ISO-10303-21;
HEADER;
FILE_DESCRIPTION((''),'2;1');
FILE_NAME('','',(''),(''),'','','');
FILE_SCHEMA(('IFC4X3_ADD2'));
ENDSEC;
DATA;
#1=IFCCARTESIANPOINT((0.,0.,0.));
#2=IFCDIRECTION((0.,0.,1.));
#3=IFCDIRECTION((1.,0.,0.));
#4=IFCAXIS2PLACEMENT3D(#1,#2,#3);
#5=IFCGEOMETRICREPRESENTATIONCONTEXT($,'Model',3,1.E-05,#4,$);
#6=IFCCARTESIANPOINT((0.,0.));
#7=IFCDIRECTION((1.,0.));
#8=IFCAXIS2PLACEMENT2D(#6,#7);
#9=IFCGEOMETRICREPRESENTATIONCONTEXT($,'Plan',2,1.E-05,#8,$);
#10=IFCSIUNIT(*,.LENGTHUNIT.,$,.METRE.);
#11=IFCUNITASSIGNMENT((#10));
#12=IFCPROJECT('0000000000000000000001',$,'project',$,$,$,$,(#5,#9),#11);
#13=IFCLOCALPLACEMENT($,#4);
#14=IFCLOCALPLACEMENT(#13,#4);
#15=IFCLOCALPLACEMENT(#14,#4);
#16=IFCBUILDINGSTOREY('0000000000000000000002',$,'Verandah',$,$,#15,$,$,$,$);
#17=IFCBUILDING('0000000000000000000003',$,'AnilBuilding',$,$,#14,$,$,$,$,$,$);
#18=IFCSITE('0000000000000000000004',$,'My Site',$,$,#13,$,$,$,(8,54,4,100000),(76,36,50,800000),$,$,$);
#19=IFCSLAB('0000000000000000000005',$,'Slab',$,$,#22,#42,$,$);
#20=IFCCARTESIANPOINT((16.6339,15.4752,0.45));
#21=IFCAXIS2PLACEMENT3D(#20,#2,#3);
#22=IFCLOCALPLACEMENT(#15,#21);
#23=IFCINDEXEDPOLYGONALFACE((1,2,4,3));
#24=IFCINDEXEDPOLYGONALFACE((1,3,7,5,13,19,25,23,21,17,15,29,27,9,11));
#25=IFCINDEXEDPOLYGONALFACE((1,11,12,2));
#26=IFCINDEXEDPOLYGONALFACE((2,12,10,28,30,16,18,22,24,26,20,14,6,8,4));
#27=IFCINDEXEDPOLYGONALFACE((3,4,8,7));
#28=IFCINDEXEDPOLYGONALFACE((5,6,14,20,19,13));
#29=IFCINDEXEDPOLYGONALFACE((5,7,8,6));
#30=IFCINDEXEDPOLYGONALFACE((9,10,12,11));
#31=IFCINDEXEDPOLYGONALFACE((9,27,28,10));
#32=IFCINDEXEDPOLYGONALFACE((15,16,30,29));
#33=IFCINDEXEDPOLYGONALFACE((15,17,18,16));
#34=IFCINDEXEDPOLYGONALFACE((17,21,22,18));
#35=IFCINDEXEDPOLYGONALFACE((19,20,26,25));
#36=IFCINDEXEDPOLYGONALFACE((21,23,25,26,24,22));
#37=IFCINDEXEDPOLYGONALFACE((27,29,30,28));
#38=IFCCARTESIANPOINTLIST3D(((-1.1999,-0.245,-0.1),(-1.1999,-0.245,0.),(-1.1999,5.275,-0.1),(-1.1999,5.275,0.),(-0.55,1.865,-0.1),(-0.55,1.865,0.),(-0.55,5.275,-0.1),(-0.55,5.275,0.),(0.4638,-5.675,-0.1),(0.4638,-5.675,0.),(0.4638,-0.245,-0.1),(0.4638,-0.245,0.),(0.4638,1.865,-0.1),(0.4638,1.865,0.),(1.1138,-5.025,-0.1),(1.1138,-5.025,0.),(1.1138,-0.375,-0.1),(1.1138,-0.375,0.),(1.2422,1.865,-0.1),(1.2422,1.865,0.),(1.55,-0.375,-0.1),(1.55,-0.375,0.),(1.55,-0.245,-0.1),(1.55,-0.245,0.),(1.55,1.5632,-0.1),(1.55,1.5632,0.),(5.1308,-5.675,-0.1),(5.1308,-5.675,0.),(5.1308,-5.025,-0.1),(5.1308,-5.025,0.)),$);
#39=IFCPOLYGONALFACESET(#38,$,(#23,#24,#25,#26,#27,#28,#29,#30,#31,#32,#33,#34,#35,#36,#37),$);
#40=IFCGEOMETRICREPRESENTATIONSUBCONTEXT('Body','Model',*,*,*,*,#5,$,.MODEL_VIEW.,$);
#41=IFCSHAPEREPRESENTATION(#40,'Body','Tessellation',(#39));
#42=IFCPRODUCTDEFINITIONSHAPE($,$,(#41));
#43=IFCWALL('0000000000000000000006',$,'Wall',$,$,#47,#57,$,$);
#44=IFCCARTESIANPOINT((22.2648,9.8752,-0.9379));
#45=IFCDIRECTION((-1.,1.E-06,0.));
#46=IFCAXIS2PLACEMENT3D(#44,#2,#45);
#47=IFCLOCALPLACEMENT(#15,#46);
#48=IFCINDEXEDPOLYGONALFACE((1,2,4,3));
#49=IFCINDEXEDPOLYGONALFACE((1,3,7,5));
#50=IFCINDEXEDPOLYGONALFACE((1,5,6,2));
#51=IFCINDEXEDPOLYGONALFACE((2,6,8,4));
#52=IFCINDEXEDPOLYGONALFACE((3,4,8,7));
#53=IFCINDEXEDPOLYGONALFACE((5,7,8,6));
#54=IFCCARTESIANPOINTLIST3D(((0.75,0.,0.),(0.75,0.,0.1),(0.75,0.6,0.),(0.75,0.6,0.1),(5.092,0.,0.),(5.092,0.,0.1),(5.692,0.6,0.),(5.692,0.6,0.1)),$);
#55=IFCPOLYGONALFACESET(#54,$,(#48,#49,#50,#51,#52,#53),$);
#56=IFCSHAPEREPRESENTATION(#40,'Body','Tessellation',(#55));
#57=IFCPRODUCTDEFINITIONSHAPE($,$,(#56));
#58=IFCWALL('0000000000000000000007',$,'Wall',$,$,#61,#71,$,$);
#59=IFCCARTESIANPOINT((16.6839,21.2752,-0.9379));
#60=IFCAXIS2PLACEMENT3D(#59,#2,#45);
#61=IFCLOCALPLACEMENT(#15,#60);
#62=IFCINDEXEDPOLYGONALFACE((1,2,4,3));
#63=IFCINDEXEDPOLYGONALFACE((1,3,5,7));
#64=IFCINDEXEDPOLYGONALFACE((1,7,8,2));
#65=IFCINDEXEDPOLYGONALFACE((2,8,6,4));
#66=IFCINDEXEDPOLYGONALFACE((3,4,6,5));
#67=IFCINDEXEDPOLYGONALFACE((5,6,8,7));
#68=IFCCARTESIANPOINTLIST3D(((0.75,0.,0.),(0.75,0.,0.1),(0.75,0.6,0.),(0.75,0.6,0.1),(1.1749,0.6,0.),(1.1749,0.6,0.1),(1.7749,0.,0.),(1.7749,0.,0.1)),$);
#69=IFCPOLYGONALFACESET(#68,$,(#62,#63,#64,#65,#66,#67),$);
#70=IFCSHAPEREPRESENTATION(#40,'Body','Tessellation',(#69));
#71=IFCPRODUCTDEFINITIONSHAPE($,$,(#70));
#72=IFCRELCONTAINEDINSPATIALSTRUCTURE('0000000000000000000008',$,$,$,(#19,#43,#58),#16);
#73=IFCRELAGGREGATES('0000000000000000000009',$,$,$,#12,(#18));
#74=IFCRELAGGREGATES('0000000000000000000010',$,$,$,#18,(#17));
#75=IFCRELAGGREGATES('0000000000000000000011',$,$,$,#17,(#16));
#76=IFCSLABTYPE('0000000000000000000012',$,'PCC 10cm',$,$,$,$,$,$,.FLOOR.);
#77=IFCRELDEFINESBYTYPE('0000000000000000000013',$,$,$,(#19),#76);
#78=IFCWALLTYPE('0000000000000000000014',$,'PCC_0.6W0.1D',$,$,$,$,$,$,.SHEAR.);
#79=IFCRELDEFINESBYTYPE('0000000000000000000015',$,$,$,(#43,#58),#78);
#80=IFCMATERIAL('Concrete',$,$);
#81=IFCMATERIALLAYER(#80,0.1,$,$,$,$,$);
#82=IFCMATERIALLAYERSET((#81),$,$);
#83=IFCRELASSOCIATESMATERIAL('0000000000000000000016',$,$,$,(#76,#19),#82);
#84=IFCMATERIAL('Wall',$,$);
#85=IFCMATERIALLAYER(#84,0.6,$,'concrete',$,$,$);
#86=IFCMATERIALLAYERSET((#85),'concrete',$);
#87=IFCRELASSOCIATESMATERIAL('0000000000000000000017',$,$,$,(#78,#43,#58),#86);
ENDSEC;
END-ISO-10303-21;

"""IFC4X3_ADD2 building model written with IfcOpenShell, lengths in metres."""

from ifc_helpers import new_model, si_unit, frame, origin_with_axes, origin_2d_with_axis, place, context, subcontext, project, spatial, line, indexed_curve, outline, extrude, material, layer, layer_set, layer_usage, type_object, element, save


model = new_model("IFC4X3_ADD2")

# Units and contexts
model_context = context("Model", 3, precision=1e-05, world=origin_with_axes())
plan_context = context("Plan", 2, precision=1e-05, world=origin_2d_with_axis())
body_context = subcontext(model_context, "Body", "Model", "MODEL_VIEW")
ifc_project = project(units=[si_unit("LENGTHUNIT", "METRE")], contexts=[model_context, plan_context])

# Site, building, storey
site_placement = place(None, origin_with_axes())
site = spatial("IfcSite", under=ifc_project, at=site_placement, Name="My Site", RefLatitude=(8, 54, 4, 100000), RefLongitude=(76, 36, 50, 800000))
building_placement = place(site_placement, origin_with_axes())
building = spatial("IfcBuilding", under=site, at=building_placement, Name="AnilBuilding")
storey_placement = place(building_placement, origin_with_axes())
storey = spatial("IfcBuildingStorey", under=building, at=storey_placement, Name="Verandah")

# Slab
ifc_material_1 = material(Name="Concrete")
ifc_layer_1 = layer(ifc_material_1, 0.1)
ifc_layer_set_1 = layer_set([ifc_layer_1])
ifc_layer_usage_1 = layer_usage(ifc_layer_set_1, "AXIS3", "POSITIVE", -0.1)
slab_type = type_object("IfcSlabType", Name="PCC 10cm", PredefinedType="FLOOR", material=ifc_layer_set_1)
slab_placement = place(storey_placement, frame((16.6339, 15.4752, 0.45), z_axis=(0.0, 0.0, 1.0), x_axis=(1.0, 0.0, 0.0)))
element("IfcSlab", 1, at=slab_placement, inside=storey, type_object=slab_type, material=ifc_layer_usage_1, Name="Slab", context=body_context, shape_type="SweptSolid", body=[
    extrude(outline(indexed_curve([(1.55, -0.375), (1.1138, -0.375), (1.1138, -5.025), (5.1308, -5.025), (5.1308, -5.675), (0.4638, -5.675), (0.4638, -0.245), (-1.1999, -0.245), (-1.1999, 5.275), (-0.55, 5.275), (-0.55, 1.865), (0.4638, 1.865), (1.2422, 1.865), (1.55, 1.5632), (1.55, -0.245), (1.55, -0.375)])), frame((0.0, 0.0, -0.1), z_axis=(0.0, 0.0, 1.0), x_axis=(1.0, 0.0, 0.0)), (0.0, 0.0, 1.0), 0.1),
])

# Walls
ifc_material_2 = material(Name="Wall")
ifc_layer_2 = layer(ifc_material_2, 0.6, Name="concrete")
ifc_layer_set_2 = layer_set([ifc_layer_2], Name="concrete")
wall_type_1 = type_object("IfcWallType", Name="PCC_0.6W0.1D", PredefinedType="SHEAR", material=ifc_layer_set_2)
ifc_layer_usage_2 = layer_usage(ifc_layer_set_2, "AXIS2", "POSITIVE", 0.0)
wall_1_placement = place(storey_placement, frame((22.2648, 9.8752, -0.9379), z_axis=(0.0, 0.0, 1.0), x_axis=(-1.0, 0.000001, 0.0)))
element("IfcWall", 2, at=wall_1_placement, inside=storey, type_object=wall_type_1, material=ifc_layer_usage_2, Name="Wall", context=body_context, shape_type="SweptSolid", body=[
    extrude(outline(indexed_curve([(0.75, 0.0), (0.75, 0.6), (5.692, 0.6), (5.092, 0.0)], segments=[line(1, 2, 3, 4, 1)])), origin_with_axes(), (0.0, 0.0, 1.0), 0.1),
])
ifc_layer_usage_3 = layer_usage(ifc_layer_set_2, "AXIS2", "POSITIVE", 0.0)
wall_2_placement = place(storey_placement, frame((16.6839, 21.2752, -0.9379), z_axis=(0.0, 0.0, 1.0), x_axis=(-1.0, 0.000001, 0.0)))
element("IfcWall", 3, at=wall_2_placement, inside=storey, type_object=wall_type_1, material=ifc_layer_usage_3, Name="Wall", context=body_context, shape_type="SweptSolid", body=[
    extrude(outline(indexed_curve([(0.75, 0.0), (0.75, 0.6), (1.1749, 0.6), (1.7749, 0.0)], segments=[line(1, 2, 3, 4, 1)])), origin_with_axes(), (0.0, 0.0, 1.0), 0.1),
])

save(model, "model.ifc")
